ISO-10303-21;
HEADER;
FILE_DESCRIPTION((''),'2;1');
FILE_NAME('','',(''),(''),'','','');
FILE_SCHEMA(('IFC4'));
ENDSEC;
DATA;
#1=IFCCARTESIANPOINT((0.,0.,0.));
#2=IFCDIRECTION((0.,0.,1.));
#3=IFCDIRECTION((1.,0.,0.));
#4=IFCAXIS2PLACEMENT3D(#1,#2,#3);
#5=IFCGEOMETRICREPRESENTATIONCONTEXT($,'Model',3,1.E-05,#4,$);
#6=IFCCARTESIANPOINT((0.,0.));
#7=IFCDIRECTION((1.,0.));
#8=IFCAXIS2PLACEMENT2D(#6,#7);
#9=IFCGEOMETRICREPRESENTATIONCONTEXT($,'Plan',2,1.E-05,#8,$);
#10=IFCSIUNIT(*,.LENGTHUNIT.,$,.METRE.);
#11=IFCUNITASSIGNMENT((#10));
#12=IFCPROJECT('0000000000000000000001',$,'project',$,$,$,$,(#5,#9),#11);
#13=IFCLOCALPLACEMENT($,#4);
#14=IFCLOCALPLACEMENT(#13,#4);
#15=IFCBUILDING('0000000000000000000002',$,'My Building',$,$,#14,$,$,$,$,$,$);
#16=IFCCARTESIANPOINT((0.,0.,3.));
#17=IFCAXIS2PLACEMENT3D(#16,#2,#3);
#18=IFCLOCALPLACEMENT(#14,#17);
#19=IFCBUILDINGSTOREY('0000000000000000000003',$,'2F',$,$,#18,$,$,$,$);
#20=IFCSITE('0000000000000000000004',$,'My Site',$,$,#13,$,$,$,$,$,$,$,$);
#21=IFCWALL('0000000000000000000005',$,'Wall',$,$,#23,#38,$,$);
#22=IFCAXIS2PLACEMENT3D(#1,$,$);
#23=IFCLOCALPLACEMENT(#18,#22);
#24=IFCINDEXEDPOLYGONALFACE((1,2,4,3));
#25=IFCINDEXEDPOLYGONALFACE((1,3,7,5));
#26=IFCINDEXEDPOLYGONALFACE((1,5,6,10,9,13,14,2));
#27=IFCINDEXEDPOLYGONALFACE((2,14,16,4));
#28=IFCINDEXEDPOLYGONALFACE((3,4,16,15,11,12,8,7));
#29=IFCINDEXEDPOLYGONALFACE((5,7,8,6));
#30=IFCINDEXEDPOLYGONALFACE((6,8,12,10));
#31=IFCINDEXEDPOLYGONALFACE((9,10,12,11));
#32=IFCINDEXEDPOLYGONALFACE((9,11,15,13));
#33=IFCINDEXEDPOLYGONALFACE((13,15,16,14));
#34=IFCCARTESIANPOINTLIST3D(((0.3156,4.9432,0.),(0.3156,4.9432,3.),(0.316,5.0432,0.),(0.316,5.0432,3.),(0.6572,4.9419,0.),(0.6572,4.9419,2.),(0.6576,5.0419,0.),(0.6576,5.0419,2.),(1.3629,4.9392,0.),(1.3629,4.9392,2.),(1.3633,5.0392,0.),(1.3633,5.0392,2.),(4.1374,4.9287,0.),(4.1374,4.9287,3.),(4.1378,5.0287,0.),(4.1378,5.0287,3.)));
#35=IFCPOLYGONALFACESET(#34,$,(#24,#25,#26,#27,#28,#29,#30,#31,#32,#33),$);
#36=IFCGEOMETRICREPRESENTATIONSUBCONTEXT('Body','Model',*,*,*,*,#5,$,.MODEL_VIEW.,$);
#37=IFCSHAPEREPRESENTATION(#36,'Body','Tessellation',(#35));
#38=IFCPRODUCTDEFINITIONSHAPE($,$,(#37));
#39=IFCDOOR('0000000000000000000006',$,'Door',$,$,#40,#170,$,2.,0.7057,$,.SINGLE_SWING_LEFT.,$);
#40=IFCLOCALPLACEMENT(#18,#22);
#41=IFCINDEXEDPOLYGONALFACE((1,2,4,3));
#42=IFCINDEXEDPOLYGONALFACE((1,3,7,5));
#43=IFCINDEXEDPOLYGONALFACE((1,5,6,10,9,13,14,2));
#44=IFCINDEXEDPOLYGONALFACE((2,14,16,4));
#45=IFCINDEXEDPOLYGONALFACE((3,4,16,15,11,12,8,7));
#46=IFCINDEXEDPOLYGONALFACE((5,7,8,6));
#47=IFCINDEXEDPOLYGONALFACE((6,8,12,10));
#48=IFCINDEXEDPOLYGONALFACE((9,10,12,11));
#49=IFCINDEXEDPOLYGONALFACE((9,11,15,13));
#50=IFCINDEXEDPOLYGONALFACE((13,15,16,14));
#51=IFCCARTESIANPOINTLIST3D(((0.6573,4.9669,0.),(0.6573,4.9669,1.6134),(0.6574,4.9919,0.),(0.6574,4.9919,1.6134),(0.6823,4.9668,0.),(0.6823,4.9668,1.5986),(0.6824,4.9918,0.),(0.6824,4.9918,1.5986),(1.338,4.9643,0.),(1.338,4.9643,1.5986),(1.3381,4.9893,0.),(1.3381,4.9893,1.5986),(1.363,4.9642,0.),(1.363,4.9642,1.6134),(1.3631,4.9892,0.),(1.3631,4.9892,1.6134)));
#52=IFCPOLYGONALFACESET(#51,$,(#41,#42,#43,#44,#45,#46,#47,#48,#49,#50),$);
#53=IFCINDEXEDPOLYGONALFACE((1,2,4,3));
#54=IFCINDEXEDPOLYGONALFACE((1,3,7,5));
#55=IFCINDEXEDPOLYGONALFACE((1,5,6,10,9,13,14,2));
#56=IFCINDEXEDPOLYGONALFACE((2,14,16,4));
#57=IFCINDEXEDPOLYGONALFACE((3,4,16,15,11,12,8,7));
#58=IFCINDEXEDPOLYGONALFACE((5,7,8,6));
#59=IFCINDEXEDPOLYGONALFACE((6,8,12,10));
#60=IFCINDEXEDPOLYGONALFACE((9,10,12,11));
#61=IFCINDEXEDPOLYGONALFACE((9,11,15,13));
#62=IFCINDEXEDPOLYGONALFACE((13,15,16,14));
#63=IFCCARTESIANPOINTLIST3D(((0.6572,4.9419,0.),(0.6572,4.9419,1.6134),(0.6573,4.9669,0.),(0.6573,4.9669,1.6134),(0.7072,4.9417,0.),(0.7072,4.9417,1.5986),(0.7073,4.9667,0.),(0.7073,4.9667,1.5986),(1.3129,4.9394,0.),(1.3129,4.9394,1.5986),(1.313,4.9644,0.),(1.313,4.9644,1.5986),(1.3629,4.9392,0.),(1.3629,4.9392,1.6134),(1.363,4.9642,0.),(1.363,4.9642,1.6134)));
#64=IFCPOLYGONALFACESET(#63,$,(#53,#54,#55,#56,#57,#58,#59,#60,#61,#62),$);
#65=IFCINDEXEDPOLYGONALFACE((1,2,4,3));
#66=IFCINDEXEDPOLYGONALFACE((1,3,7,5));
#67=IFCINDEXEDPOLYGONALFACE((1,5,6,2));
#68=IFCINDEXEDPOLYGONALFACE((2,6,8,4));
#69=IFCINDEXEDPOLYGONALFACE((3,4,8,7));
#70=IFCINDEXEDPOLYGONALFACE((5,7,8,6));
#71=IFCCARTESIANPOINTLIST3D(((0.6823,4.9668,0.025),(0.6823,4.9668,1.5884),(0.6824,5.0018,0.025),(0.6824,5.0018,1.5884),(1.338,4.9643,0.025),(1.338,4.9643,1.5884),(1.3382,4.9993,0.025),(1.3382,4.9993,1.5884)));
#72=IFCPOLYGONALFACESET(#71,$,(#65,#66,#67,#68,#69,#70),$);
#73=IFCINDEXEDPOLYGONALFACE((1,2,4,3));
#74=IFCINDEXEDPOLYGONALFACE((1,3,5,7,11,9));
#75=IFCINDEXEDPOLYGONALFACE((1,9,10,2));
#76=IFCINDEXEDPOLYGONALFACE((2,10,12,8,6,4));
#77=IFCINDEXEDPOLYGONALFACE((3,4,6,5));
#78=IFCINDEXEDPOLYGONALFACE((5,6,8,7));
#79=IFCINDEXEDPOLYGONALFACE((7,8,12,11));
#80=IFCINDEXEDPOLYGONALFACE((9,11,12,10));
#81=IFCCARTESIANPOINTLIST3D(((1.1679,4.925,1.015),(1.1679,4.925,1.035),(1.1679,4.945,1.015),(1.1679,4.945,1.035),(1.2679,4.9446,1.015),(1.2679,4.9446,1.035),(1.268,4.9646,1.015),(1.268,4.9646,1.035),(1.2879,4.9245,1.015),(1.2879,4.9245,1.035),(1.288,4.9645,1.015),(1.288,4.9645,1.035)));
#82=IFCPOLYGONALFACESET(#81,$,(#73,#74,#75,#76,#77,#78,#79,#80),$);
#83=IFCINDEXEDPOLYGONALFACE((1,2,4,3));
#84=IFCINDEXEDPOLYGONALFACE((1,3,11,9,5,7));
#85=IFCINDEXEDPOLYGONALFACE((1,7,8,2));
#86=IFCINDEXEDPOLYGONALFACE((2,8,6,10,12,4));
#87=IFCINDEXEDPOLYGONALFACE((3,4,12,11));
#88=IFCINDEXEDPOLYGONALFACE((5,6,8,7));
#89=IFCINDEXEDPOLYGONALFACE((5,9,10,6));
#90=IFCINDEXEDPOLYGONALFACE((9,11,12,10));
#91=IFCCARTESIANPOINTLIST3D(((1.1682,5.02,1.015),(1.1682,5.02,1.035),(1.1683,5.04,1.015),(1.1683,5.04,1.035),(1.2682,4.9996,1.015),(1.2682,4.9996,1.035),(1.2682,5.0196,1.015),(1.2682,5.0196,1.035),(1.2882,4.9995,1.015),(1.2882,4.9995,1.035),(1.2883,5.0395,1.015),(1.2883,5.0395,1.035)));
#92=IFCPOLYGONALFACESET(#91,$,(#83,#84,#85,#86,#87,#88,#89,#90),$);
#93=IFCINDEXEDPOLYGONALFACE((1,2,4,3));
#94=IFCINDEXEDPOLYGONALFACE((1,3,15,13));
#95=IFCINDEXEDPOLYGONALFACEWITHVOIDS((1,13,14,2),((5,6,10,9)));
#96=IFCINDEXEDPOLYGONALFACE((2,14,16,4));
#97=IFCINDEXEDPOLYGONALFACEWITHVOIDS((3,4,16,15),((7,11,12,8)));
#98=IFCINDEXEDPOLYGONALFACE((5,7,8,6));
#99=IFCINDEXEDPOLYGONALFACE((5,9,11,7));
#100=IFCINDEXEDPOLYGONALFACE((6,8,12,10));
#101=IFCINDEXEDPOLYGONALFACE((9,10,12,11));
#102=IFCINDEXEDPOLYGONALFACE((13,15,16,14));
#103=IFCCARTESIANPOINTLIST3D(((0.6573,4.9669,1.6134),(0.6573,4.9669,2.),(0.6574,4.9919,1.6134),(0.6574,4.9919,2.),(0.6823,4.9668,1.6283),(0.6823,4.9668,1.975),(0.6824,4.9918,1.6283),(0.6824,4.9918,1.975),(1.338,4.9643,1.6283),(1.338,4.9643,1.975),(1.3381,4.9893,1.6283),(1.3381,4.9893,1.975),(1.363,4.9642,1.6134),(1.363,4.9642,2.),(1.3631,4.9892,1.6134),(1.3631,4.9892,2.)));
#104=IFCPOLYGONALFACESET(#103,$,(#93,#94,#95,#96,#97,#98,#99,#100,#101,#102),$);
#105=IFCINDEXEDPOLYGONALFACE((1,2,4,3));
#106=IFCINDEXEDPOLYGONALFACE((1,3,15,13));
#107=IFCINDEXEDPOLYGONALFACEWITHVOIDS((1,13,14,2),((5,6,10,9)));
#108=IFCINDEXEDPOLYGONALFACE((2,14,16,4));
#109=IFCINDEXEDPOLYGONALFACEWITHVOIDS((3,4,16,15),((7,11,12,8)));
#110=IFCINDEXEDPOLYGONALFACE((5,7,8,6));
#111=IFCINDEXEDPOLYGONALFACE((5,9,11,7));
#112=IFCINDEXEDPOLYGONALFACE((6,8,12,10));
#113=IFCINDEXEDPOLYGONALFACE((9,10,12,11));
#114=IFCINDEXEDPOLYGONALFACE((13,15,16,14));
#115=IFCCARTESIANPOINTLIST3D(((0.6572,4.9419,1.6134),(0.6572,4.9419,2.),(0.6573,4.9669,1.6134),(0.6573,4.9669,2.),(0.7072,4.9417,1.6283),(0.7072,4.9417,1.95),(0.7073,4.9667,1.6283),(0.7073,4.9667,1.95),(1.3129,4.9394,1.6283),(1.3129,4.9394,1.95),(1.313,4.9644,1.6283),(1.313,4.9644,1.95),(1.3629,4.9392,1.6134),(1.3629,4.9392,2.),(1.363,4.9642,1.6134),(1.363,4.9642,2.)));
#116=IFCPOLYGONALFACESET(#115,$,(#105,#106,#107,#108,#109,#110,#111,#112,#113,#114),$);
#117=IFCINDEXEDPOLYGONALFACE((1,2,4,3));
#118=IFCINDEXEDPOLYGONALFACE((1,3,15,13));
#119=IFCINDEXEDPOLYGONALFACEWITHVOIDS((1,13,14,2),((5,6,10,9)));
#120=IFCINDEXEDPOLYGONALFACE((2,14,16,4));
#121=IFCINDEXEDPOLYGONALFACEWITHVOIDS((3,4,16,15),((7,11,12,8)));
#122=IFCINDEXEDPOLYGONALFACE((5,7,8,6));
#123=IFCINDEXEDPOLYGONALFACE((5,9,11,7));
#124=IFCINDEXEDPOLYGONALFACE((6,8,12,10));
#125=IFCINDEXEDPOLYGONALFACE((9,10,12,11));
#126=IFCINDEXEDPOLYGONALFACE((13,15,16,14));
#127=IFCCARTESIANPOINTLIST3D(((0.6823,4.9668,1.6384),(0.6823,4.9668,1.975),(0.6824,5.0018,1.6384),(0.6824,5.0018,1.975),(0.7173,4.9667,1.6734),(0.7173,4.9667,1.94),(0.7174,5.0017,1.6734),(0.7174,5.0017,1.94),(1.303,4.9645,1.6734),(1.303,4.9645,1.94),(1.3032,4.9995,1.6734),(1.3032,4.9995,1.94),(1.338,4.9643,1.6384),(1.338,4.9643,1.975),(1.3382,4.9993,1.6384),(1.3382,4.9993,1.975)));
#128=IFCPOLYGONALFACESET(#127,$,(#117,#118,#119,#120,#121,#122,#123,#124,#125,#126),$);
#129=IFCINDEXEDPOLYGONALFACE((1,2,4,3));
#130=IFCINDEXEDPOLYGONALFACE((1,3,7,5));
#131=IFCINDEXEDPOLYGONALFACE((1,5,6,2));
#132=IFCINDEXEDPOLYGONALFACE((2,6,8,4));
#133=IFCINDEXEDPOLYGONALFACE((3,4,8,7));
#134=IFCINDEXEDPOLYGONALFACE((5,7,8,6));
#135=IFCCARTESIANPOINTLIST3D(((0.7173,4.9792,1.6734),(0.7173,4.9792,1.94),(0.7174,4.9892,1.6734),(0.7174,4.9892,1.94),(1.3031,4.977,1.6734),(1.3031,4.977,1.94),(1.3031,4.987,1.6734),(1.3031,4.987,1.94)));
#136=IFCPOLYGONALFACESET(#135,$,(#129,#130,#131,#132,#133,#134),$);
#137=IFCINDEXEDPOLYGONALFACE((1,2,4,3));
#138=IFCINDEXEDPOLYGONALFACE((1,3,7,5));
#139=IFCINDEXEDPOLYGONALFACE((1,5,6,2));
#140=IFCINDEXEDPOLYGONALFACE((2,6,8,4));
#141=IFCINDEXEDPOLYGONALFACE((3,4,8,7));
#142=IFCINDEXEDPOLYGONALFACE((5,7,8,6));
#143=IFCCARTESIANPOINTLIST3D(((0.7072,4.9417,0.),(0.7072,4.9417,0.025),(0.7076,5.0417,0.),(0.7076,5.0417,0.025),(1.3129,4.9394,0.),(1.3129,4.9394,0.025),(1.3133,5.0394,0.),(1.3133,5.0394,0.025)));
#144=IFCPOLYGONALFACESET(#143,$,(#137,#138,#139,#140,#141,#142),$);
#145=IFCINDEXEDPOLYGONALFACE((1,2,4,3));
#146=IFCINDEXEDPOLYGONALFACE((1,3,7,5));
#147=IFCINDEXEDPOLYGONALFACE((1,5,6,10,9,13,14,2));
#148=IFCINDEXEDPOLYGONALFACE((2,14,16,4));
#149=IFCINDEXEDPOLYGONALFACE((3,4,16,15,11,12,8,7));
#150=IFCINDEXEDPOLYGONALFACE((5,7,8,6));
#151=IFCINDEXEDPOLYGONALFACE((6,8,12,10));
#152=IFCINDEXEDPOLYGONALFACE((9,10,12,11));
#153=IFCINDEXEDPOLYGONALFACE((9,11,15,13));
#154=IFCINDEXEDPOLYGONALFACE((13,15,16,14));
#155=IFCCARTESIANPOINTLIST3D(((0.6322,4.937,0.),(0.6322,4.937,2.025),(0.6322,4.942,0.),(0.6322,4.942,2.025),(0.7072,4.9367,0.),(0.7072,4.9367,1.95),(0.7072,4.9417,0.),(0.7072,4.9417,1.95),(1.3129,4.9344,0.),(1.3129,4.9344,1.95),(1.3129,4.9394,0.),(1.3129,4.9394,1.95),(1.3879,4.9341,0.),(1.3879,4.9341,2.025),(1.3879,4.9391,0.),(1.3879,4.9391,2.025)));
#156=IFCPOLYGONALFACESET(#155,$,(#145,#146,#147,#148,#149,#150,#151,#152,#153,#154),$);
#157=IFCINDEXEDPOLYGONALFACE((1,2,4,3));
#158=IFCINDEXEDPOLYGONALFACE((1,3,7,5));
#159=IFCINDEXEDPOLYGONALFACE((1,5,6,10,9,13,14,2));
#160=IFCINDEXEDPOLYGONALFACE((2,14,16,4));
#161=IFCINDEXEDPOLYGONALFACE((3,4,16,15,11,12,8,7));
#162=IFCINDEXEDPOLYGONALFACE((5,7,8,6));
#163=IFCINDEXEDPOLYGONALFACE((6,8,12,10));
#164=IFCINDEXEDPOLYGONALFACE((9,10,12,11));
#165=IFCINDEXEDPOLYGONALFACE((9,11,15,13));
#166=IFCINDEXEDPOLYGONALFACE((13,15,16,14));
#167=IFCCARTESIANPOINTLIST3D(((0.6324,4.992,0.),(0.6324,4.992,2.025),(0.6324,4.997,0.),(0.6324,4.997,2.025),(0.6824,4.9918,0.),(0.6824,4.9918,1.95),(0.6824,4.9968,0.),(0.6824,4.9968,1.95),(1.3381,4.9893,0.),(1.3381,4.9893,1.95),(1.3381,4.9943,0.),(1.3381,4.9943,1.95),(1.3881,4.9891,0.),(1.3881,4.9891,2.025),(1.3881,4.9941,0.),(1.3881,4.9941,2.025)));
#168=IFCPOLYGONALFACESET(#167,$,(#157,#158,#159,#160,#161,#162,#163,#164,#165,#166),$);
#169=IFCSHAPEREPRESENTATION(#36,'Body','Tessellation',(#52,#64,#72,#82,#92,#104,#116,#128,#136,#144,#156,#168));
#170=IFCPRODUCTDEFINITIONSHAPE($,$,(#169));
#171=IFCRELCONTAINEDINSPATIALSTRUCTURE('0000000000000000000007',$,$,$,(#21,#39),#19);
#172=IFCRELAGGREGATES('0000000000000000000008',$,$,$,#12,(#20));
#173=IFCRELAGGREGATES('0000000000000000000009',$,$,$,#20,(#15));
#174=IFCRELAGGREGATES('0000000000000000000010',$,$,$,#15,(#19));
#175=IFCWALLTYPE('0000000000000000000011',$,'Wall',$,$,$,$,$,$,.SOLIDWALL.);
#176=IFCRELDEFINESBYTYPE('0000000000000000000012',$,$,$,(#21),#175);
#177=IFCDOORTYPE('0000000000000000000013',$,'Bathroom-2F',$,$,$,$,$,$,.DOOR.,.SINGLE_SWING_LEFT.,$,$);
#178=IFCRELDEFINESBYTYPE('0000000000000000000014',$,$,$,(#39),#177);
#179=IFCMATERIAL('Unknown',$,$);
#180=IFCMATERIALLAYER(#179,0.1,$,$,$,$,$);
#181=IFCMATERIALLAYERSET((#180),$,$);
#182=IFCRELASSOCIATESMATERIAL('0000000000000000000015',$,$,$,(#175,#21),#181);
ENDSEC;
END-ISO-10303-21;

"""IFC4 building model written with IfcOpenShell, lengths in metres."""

from ifc_helpers import new_model, entity, si_unit, frame, origin_with_axes, origin_2d_with_axis, place, context, subcontext, project, spatial, line, indexed_curve, outline, extrude, shape, source, transform, mapped, material, layer, layer_set, layer_usage, type_object, type_shapes, element, fill, save


model = new_model("IFC4")

# Units and contexts
model_context = context("Model", 3, precision=1e-05, world=origin_with_axes())
plan_context = context("Plan", 2, precision=1e-05, world=origin_2d_with_axis())
body_context_1 = subcontext(model_context, "Body", "Model", "MODEL_VIEW")
body_context_2 = subcontext(plan_context, "Body", "Plan", "PLAN_VIEW")
ifc_project = project(units=[si_unit("LENGTHUNIT", "METRE")], contexts=[model_context, plan_context])

# Site, building, storey
site_placement = place(None, origin_with_axes())
site = spatial("IfcSite", under=ifc_project, at=site_placement, Name="My Site")
building_placement = place(site_placement, origin_with_axes())
building = spatial("IfcBuilding", under=site, at=building_placement, Name="My Building")
storey_placement = place(building_placement, frame((0.0, 0.0, 3.0), z_axis=(0.0, 0.0, 1.0), x_axis=(1.0, 0.0, 0.0)))
storey = spatial("IfcBuildingStorey", under=building, at=storey_placement, Name="2F")

# Shared definitions
ifc_material = material(Name="Unknown")
ifc_layer = layer(ifc_material, 0.1)
ifc_layer_set = layer_set([ifc_layer])
wall_type = type_object("IfcWallType", Name="Wall", PredefinedType="SOLIDWALL", material=ifc_layer_set)

# Wall, opening, door
ifc_layer_usage_1 = layer_usage(ifc_layer_set, "AXIS2", "POSITIVE", 0.0)
wall_1_placement = place(storey_placement, frame((4.1378, 5.0287, 0.0), z_axis=(0.0, 0.0, 1.0), x_axis=(-0.999993, 0.003807, 0.0)))
wall_1 = element("IfcWall", 1, at=wall_1_placement, inside=storey, type_object=wall_type, material=ifc_layer_usage_1, Name="Wall", context=body_context_1, shape_type="SweptSolid", body=[
    extrude(outline(indexed_curve([(0.0, 0.0), (0.0, 0.1), (3.8218, 0.1), (3.8218, 0.0)], segments=[line(1, 2, 3, 4, 1)])), origin_with_axes(), (0.0, 0.0, 1.0), 3.0),
])
shared_shape_1 = source(origin_with_axes(), body_context_1, "Body", "SweptSolid", [
    extrude(outline(indexed_curve([(0.0, 0.0), (0.7057, 0.0), (0.7057, 2.0), (0.0, 2.0)], segments=[line(1, 2, 3, 4, 1)])), frame((0.0, -0.6, 0.0), z_axis=(0.0, -1.0, 0.0), x_axis=(1.0, 0.0, 0.0)), (0.0, 0.0, -1.0), 1.2),
])
opening_1_placement = place(wall_1_placement, frame((3.4802, 0.1, 0.0), z_axis=(0.0, 0.0, 1.0), x_axis=(-1.0, 0.000001, 0.0)))
opening_1 = element("IfcOpeningElement", 2, at=opening_1_placement, cuts=wall_1, PredefinedType="OPENING", context=body_context_1, shape_type="MappedRepresentation", body=[
    mapped(shared_shape_1, transform((0.0, 0.0, 0.0), x_axis=(1.0, 0.0, 0.0), y_axis=(0.0, 1.0, 0.0), z_axis=(0.0, 0.0, 1.0), scale=1.0)),
])
door_type_1 = type_object("IfcDoorType", Name="Bathroom-2F", OperationType="SINGLE_SWING_LEFT", PredefinedType="DOOR")
shared_shape_2 = source(origin_with_axes(), body_context_1, "Body", "SweptSolid", [
    extrude(outline(indexed_curve([(0.0, 0.0), (0.0, 1.6134), (0.7057, 1.6134), (0.7057, 0.0), (0.6807, 0.0), (0.6807, 1.5986), (0.025, 1.5986), (0.025, 0.0)], segments=[line(1, 2, 3, 4, 5, 6, 7, 8, 1)])), frame((0.0, 0.025, 0.0), z_axis=(0.0, -1.0, 0.0), x_axis=(1.0, 0.0, 0.0)), (0.0, 0.0, -1.0), 0.025),
    extrude(outline(indexed_curve([(0.0, 0.0), (0.0, 1.6134), (0.7057, 1.6134), (0.7057, 0.0), (0.6557, 0.0), (0.6557, 1.5986), (0.05, 1.5986), (0.05, 0.0)], segments=[line(1, 2, 3, 4, 5, 6, 7, 8, 1)])), frame((0.0, 0.0, 0.0), z_axis=(0.0, -1.0, 0.0), x_axis=(1.0, 0.0, 0.0)), (0.0, 0.0, -1.0), 0.025),
    extrude(outline(indexed_curve([(0.0, 0.0), (0.6557, 0.0), (0.6557, 0.035), (0.0, 0.035)], segments=[line(1, 2, 3, 4, 1)])), frame((0.025, 0.025, 0.025), z_axis=(0.0, 0.0, 1.0), x_axis=(1.0, 0.0, 0.0)), (0.0, 0.0, 1.0), 1.5634),
    extrude(outline(indexed_curve([(0.0, 0.0), (0.0, -0.04), (-0.12, -0.04), (-0.12, -0.02), (-0.02, -0.02), (-0.02, 0.0)], segments=[line(1, 2, 3, 4, 5, 6, 1)])), frame((0.6307, 0.025, 1.015), z_axis=(0.0, 0.0, 1.0), x_axis=(1.0, 0.0, 0.0)), (0.0, 0.0, 1.0), 0.02),
    extrude(outline(indexed_curve([(0.0, 0.0), (0.0, 0.04), (-0.12, 0.04), (-0.12, 0.02), (-0.02, 0.02), (-0.02, 0.0)], segments=[line(1, 2, 3, 4, 5, 6, 1)])), frame((0.6307, 0.06, 1.015), z_axis=(0.0, 0.0, 1.0), x_axis=(1.0, 0.0, 0.0)), (0.0, 0.0, 1.0), 0.02),
    extrude(outline(indexed_curve([(0.0, 0.0), (0.7057, 0.0), (0.7057, 0.3866), (0.0, 0.3866)], segments=[line(1, 2, 3, 4, 1)]), holes=[indexed_curve([(0.025, 0.0148), (0.6807, 0.0148), (0.6807, 0.3616), (0.025, 0.3616)], segments=[line(1, 2, 3, 4, 1)])]), frame((0.0, 0.025, 1.6134), z_axis=(0.0, -1.0, 0.0), x_axis=(1.0, 0.0, 0.0)), (0.0, 0.0, -1.0), 0.025),
    extrude(outline(indexed_curve([(0.0, 0.0), (0.7057, 0.0), (0.7057, 0.3866), (0.0, 0.3866)], segments=[line(1, 2, 3, 4, 1)]), holes=[indexed_curve([(0.05, 0.0148), (0.6557, 0.0148), (0.6557, 0.3366), (0.05, 0.3366)], segments=[line(1, 2, 3, 4, 1)])]), frame((0.0, 0.0, 1.6134), z_axis=(0.0, -1.0, 0.0), x_axis=(1.0, 0.0, 0.0)), (0.0, 0.0, -1.0), 0.025),
    extrude(outline(indexed_curve([(0.0, 0.0), (0.6557, 0.0), (0.6557, 0.3366), (0.0, 0.3366)], segments=[line(1, 2, 3, 4, 1)]), holes=[indexed_curve([(0.035, 0.035), (0.6207, 0.035), (0.6207, 0.3016), (0.035, 0.3016)], segments=[line(1, 2, 3, 4, 1)])]), frame((0.025, 0.025, 1.6384), z_axis=(0.0, -1.0, 0.0), x_axis=(1.0, 0.0, 0.0)), (0.0, 0.0, -1.0), 0.035),
    extrude(outline(indexed_curve([(0.035, 0.035), (0.6207, 0.035), (0.6207, 0.3016), (0.035, 0.3016)], segments=[line(1, 2, 3, 4, 1)])), frame((0.025, 0.0375, 1.6384), z_axis=(0.0, -1.0, 0.0), x_axis=(1.0, 0.0, 0.0)), (0.0, 0.0, -1.0), 0.01),
    extrude(outline(indexed_curve([(0.0, 0.0), (0.6057, 0.0), (0.6057, 0.1), (0.0, 0.1)], segments=[line(1, 2, 3, 4, 1)])), frame((0.05, 0.0, 0.0), z_axis=(0.0, 0.0, 1.0), x_axis=(1.0, 0.0, 0.0)), (0.0, 0.0, 1.0), 0.025),
    extrude(outline(indexed_curve([(0.0, 0.0), (0.0, 2.025), (0.7557, 2.025), (0.7557, 0.0), (0.6807, 0.0), (0.6807, 1.95), (0.075, 1.95), (0.075, 0.0)], segments=[line(1, 2, 3, 4, 5, 6, 7, 8, 1)])), frame((-0.025, -0.005, 0.0), z_axis=(0.0, -1.0, 0.0), x_axis=(1.0, 0.0, 0.0)), (0.0, 0.0, -1.0), 0.005),
    extrude(outline(indexed_curve([(0.0, 0.0), (0.0, 2.025), (0.7557, 2.025), (0.7557, 0.0), (0.7057, 0.0), (0.7057, 1.95), (0.05, 1.95), (0.05, 0.0)], segments=[line(1, 2, 3, 4, 5, 6, 7, 8, 1)])), frame((-0.025, 0.05, 0.0), z_axis=(0.0, -1.0, 0.0), x_axis=(1.0, 0.0, 0.0)), (0.0, 0.0, -1.0), 0.005),
])
shared_shape_3 = source(origin_with_axes(), body_context_2, "Body", "Curve2D", [
    entity("IfcIndexedPolyCurve", entity("IfcCartesianPointList2D", [[0.0, 0.0], [0.0, 0.05], [0.025, 0.05], [0.025, 0.025], [0.05, 0.025], [0.05, 0.0]]), [entity("IfcLineIndex", [1, 2, 3, 4, 5, 6, 1])]),
    entity("IfcIndexedPolyCurve", entity("IfcCartesianPointList2D", [[0.7057, 0.0], [0.7057, 0.05], [0.6807, 0.05], [0.6807, 0.025], [0.6557, 0.025], [0.6557, 0.0]]), [entity("IfcLineIndex", [1, 2, 3, 4, 5, 6, 1])]),
    entity("IfcTrimmedCurve", entity("IfcEllipse", entity("IfcAxis2Placement2D", entity("IfcCartesianPoint", [0.06, 0.05]), entity("IfcDirection", [1.0, 0.0])), 0.6207, 0.6557), [entity("IfcCartesianPoint", [0.6807, 0.05])], [entity("IfcCartesianPoint", [0.06, 0.7057])], True, "CARTESIAN"),
    entity("IfcIndexedPolyCurve", entity("IfcCartesianPointList2D", [[0.025, 0.05], [0.06, 0.05], [0.06, 0.7057], [0.025, 0.7057]]), [entity("IfcLineIndex", [1, 2, 3, 4, 1])]),
])
type_shapes(door_type_1, [shared_shape_2, shared_shape_3])
door_1_placement = place(opening_1_placement, frame((0.0, 0.0, 0.0), z_axis=(0.0, 0.0, 1.0), x_axis=(1.0, 0.0, 0.0)))
door_1 = element("IfcDoor", 3, at=door_1_placement, inside=storey, type_object=door_type_1, Name="Door", OperationType="SINGLE_SWING_LEFT", OverallHeight=2.0, OverallWidth=0.7057, shapes=[
    shape(body_context_1, "Body", "MappedRepresentation", [mapped(shared_shape_2, transform((0.0, 0.0, 0.0), x_axis=(1.0, 0.0, 0.0), y_axis=(0.0, 1.0, 0.0), z_axis=(0.0, 0.0, 1.0), scale=1.0))]),
    shape(body_context_2, "Body", "MappedRepresentation", [mapped(shared_shape_3, transform((0.0, 0.0, 0.0), x_axis=(1.0, 0.0, 0.0), y_axis=(0.0, 1.0, 0.0), z_axis=(0.0, 0.0, 1.0), scale=1.0))]),
])
fill(opening_1, door_1)

save(model, "model.ifc")
